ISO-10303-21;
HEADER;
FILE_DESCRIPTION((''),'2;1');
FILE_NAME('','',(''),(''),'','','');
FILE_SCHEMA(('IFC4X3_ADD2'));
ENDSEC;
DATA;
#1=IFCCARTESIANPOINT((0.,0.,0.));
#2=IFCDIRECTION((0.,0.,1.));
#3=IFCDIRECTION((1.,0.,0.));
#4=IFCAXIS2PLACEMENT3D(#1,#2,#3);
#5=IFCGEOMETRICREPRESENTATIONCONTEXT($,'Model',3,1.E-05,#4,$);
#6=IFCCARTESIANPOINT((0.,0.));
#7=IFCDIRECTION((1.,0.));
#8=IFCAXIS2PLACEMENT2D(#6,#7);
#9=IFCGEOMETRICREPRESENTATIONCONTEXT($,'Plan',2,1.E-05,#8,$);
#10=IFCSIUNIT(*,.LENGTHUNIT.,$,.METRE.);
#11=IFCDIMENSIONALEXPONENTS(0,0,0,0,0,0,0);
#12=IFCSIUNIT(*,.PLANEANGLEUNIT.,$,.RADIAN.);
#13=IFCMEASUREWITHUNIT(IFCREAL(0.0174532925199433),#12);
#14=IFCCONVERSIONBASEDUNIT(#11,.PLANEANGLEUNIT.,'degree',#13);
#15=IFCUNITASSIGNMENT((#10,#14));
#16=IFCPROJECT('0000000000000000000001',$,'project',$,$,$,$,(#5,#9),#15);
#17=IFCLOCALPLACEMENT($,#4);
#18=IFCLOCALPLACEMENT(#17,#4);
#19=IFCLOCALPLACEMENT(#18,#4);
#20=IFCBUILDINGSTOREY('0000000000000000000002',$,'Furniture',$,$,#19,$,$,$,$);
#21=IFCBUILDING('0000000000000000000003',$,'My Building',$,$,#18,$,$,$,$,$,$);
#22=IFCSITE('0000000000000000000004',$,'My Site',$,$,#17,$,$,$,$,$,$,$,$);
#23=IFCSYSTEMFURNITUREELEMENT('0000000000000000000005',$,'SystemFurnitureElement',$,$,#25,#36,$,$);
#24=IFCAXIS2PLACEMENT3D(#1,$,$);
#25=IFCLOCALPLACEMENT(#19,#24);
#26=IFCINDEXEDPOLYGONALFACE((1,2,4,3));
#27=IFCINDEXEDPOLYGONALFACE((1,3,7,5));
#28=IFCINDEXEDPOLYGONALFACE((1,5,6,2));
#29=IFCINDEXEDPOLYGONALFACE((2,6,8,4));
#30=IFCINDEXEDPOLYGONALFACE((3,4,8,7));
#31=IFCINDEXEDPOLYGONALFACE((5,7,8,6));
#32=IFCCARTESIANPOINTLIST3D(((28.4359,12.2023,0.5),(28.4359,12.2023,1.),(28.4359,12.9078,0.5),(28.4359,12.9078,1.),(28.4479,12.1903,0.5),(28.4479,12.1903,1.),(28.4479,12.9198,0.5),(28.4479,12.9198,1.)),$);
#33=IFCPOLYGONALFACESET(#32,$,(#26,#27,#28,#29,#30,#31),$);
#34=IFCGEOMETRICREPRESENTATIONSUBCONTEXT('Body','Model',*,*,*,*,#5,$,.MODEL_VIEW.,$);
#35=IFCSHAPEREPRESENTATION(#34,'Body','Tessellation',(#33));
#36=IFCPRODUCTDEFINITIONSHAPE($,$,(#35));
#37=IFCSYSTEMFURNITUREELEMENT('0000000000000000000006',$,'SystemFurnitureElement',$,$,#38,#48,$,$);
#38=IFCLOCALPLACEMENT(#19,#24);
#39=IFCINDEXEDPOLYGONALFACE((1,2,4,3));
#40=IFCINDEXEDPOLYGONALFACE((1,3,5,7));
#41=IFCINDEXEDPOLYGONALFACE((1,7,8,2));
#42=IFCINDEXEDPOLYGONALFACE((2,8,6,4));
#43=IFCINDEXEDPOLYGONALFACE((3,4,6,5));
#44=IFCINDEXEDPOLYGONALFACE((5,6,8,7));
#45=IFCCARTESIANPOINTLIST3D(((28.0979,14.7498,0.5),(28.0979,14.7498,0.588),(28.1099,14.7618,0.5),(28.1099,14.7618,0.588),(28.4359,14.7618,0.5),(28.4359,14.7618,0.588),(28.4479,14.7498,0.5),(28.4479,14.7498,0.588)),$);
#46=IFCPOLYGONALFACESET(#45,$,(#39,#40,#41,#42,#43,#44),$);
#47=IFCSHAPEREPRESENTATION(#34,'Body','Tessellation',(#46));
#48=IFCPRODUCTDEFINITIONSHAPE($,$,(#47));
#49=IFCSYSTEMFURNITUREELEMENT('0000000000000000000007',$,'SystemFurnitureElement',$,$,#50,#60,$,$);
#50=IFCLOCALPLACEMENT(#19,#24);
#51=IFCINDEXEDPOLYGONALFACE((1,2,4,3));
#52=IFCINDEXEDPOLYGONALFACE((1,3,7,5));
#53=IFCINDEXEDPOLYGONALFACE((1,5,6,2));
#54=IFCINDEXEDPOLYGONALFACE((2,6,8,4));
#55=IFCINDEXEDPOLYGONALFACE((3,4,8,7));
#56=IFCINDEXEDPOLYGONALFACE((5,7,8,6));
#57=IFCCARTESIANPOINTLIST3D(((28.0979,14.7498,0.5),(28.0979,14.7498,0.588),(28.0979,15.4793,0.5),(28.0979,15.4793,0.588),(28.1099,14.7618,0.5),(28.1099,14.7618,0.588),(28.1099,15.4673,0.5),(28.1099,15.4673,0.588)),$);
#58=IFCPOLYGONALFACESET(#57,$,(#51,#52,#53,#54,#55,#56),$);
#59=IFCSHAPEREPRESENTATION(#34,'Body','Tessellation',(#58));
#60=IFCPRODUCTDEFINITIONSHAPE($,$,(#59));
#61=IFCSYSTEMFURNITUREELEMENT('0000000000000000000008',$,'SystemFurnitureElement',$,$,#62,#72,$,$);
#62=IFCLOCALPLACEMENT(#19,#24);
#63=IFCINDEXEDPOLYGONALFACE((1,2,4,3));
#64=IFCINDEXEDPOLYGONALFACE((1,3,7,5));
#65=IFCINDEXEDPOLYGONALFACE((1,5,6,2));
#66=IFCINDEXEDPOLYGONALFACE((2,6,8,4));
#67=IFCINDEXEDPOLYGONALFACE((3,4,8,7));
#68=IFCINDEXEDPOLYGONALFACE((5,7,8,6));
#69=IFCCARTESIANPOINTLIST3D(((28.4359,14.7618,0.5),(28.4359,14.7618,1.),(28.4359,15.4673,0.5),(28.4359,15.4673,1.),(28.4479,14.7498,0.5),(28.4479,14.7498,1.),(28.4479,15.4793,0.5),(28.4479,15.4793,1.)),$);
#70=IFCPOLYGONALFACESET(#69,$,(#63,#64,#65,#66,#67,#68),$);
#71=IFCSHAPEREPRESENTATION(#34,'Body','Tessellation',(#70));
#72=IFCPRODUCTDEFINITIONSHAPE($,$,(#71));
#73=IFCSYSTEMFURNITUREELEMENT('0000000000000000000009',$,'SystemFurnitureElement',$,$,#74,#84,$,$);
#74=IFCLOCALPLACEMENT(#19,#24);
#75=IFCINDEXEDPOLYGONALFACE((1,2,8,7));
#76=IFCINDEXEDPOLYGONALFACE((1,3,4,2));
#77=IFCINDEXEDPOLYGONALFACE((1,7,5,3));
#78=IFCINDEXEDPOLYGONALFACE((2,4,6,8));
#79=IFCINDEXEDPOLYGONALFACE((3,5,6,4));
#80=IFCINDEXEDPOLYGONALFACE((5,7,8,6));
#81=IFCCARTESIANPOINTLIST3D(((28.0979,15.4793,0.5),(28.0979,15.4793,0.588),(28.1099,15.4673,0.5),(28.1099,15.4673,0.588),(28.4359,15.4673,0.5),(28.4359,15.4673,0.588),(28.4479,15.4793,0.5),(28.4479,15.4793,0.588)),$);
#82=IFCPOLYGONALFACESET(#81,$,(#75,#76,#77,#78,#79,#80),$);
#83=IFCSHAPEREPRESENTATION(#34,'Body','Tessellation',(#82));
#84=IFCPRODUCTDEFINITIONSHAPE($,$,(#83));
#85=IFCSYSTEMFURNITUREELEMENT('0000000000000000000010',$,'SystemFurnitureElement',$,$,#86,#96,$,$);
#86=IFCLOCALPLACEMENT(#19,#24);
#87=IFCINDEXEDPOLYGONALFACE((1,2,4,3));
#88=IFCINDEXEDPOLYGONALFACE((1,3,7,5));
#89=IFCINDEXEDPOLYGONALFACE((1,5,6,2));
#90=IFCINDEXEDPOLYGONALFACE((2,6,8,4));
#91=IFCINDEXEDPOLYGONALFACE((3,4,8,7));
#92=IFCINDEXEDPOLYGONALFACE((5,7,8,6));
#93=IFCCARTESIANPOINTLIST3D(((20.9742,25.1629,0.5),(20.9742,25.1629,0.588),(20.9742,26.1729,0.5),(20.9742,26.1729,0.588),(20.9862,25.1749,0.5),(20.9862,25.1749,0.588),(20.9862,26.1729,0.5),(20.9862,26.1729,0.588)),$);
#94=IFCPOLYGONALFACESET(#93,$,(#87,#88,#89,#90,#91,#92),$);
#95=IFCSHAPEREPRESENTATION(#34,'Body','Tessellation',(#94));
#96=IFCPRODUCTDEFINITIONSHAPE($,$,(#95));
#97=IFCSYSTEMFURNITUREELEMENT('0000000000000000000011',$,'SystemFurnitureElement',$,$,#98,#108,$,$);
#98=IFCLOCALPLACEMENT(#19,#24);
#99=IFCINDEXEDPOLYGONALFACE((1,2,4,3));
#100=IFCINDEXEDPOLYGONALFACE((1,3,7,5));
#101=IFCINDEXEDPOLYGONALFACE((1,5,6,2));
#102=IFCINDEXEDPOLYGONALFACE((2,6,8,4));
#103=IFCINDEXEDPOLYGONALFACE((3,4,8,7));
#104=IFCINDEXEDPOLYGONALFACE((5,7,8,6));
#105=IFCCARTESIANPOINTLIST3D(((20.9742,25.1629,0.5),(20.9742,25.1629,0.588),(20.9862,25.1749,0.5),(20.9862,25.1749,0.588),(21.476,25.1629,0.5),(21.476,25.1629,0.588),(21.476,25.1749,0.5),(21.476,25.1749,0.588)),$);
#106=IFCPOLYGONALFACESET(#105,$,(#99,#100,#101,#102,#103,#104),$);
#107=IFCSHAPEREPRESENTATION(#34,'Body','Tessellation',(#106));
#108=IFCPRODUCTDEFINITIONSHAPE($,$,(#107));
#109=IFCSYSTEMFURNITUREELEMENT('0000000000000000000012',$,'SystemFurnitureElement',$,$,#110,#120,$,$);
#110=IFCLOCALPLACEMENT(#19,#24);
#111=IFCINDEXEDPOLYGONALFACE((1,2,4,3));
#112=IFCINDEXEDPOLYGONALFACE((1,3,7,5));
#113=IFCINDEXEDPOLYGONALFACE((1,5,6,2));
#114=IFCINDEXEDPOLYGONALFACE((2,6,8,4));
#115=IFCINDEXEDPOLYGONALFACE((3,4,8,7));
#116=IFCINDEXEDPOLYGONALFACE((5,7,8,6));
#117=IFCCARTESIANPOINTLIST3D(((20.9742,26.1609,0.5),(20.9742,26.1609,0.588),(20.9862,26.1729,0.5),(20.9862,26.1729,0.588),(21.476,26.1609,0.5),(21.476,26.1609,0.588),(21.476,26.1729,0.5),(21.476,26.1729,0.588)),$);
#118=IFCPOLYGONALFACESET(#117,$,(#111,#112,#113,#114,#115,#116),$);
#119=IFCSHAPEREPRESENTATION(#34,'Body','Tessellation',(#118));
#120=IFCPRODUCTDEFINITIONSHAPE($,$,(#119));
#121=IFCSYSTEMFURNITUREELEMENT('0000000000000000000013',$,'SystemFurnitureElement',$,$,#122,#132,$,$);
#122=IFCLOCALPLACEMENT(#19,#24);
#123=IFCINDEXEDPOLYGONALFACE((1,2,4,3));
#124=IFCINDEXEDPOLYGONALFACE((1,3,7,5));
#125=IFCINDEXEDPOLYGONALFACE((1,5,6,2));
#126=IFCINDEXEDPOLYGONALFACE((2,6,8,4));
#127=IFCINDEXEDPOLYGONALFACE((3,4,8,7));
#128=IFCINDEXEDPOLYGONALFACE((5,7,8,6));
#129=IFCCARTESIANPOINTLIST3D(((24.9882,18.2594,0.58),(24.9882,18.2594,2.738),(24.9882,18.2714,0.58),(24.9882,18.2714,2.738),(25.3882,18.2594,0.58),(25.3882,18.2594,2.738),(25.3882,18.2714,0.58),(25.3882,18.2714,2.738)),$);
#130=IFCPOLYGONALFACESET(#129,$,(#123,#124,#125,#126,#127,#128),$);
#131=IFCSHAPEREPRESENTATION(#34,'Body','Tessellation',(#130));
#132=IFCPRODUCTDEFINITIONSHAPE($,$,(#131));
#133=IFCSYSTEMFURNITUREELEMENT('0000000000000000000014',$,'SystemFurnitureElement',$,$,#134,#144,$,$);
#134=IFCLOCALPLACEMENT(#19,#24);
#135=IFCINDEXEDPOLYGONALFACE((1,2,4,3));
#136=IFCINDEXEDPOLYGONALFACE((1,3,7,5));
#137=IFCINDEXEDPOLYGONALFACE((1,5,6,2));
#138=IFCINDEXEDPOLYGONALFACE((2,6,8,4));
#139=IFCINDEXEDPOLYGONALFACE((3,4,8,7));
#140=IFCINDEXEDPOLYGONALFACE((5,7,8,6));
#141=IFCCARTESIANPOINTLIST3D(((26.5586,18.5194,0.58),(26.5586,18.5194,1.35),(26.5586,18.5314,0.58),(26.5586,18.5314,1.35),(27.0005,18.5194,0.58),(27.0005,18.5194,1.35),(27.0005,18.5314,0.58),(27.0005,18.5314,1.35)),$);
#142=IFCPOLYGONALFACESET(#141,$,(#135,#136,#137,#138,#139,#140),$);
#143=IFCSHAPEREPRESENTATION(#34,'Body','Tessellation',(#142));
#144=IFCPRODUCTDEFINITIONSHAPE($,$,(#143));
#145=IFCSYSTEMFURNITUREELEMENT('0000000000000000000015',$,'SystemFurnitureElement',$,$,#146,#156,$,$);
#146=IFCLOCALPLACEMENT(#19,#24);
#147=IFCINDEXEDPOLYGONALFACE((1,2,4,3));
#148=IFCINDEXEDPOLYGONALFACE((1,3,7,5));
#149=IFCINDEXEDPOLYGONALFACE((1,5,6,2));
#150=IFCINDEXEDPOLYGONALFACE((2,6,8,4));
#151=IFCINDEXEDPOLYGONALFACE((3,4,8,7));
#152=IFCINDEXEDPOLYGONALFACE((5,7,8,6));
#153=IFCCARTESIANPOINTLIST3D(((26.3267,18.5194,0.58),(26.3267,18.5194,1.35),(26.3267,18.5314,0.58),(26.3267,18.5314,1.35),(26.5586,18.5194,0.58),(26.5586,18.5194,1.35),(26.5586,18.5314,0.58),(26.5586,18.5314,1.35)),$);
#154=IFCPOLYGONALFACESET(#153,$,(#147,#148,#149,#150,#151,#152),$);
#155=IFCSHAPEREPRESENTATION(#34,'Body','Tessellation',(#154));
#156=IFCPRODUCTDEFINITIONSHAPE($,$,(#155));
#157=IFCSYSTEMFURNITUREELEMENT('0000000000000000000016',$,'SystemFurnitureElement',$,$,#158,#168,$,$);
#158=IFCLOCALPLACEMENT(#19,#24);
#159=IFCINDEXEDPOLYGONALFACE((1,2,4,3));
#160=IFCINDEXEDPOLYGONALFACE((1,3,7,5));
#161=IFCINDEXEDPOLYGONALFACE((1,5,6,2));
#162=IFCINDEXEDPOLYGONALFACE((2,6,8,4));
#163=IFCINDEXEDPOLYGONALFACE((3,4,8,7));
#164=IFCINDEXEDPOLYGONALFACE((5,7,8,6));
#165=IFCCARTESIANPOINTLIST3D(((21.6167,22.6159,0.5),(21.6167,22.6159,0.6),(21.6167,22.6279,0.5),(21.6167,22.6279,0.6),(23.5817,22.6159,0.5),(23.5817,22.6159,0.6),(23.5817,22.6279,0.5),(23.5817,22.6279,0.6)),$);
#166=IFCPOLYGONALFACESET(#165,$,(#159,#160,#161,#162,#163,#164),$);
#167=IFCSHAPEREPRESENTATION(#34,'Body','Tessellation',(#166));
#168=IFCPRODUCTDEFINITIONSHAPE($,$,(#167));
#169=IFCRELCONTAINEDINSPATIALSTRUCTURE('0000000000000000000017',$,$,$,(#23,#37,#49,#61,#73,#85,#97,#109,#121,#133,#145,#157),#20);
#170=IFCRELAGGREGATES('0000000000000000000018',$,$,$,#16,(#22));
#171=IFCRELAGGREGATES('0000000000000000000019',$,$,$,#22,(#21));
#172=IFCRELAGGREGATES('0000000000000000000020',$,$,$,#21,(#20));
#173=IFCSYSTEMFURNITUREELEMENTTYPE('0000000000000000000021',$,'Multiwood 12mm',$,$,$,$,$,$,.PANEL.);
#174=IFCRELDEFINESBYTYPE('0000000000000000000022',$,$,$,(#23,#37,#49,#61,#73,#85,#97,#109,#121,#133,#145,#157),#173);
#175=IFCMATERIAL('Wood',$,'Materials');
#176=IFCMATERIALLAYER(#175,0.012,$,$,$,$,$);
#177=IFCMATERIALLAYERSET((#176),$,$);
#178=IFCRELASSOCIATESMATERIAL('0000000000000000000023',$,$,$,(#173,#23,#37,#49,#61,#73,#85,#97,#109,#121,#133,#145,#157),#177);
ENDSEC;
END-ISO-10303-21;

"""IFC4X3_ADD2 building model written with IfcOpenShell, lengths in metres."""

from ifc_helpers import new_model, entity, si_unit, converted_unit, frame, origin_with_axes, origin_2d_with_axis, place, context, subcontext, project, spatial, line, indexed_curve, outline, extrude, material, layer, layer_set, layer_usage, type_object, element, save


model = new_model("IFC4X3_ADD2")

# Units and contexts
model_context = context("Model", 3, precision=1e-05, world=origin_with_axes())
plan_context = context("Plan", 2, precision=1e-05, world=origin_2d_with_axis())
body_context = subcontext(model_context, "Body", "Model", "MODEL_VIEW")
ifc_project = project(units=[si_unit("LENGTHUNIT", "METRE"), converted_unit("PLANEANGLEUNIT", "degree", entity("IfcReal", 0.0174532925199433), si_unit("PLANEANGLEUNIT", "RADIAN"), dimensions=[0, 0, 0, 0, 0, 0, 0])], contexts=[model_context, plan_context])

# Site, building, storey
site_placement = place(None, origin_with_axes())
site = spatial("IfcSite", under=ifc_project, at=site_placement, Name="My Site")
building_placement = place(site_placement, origin_with_axes())
building = spatial("IfcBuilding", under=site, at=building_placement, Name="My Building")
storey_placement = place(building_placement, origin_with_axes())
storey = spatial("IfcBuildingStorey", under=building, at=storey_placement, Name="Furniture")

# System furniture elements
ifc_material = material(Name="Wood", Category="Materials")
ifc_layer_1 = layer(ifc_material, 0.012)
ifc_layer_set_1 = layer_set([ifc_layer_1])
system_furniture_element_type_1 = type_object("IfcSystemFurnitureElementType", Name="Multiwood 12mm", PredefinedType="PANEL", material=ifc_layer_set_1)
ifc_layer_usage_1 = layer_usage(ifc_layer_set_1, "AXIS2", "POSITIVE", 0.0)
system_furniture_element_1_placement = place(storey_placement, frame((28.4359, 12.9078, 0.5), z_axis=(0.0, 0.0, 1.0), x_axis=(0.0, -1.0, 0.0)))
element("IfcSystemFurnitureElement", 1, at=system_furniture_element_1_placement, inside=storey, type_object=system_furniture_element_type_1, material=ifc_layer_usage_1, Name="SystemFurnitureElement", context=body_context, shape_type="SweptSolid", body=[
    extrude(outline(indexed_curve([(0.0, 0.0), (-0.012, 0.012), (0.7175, 0.012), (0.7055, 0.0)], segments=[line(1, 2, 3, 4, 1)])), origin_with_axes(), (0.0, 0.0, 1.0), 0.5),
])
ifc_layer_usage_2 = layer_usage(ifc_layer_set_1, "AXIS2", "POSITIVE", 0.0)
system_furniture_element_2_placement = place(storey_placement, frame((28.0979, 14.7498, 0.5), z_axis=(0.0, 0.0, 1.0), x_axis=(1.0, 0.0, 0.0)))
element("IfcSystemFurnitureElement", 2, at=system_furniture_element_2_placement, inside=storey, type_object=system_furniture_element_type_1, material=ifc_layer_usage_2, Name="SystemFurnitureElement", context=body_context, shape_type="SweptSolid", body=[
    extrude(outline(indexed_curve([(0.0, 0.0), (0.012, 0.012), (0.338, 0.012), (0.35, 0.0)], segments=[line(1, 2, 3, 4, 1)])), origin_with_axes(), (0.0, 0.0, 1.0), 0.088),
])
ifc_layer_usage_3 = layer_usage(ifc_layer_set_1, "AXIS2", "POSITIVE", 0.0)
system_furniture_element_3_placement = place(storey_placement, frame((28.0979, 15.4673, 0.5), z_axis=(0.0, 0.0, 1.0), x_axis=(0.0, -1.0, 0.0)))
element("IfcSystemFurnitureElement", 3, at=system_furniture_element_3_placement, inside=storey, type_object=system_furniture_element_type_1, material=ifc_layer_usage_3, Name="SystemFurnitureElement", context=body_context, shape_type="SweptSolid", body=[
    extrude(outline(indexed_curve([(-0.012, 0.0), (0.0, 0.012), (0.7055, 0.012), (0.7175, 0.0)], segments=[line(1, 2, 3, 4, 1)])), origin_with_axes(), (0.0, 0.0, 1.0), 0.088),
])
ifc_layer_usage_4 = layer_usage(ifc_layer_set_1, "AXIS2", "POSITIVE", 0.0)
system_furniture_element_4_placement = place(storey_placement, frame((28.4359, 15.4673, 0.5), z_axis=(0.0, 0.0, 1.0), x_axis=(0.0, -1.0, 0.0)))
element("IfcSystemFurnitureElement", 4, at=system_furniture_element_4_placement, inside=storey, type_object=system_furniture_element_type_1, material=ifc_layer_usage_4, Name="SystemFurnitureElement", context=body_context, shape_type="SweptSolid", body=[
    extrude(outline(indexed_curve([(0.0, 0.0), (-0.012, 0.012), (0.7175, 0.012), (0.7055, 0.0)], segments=[line(1, 2, 3, 4, 1)])), origin_with_axes(), (0.0, 0.0, 1.0), 0.5),
])
ifc_layer_usage_5 = layer_usage(ifc_layer_set_1, "AXIS2", "POSITIVE", 0.0)
system_furniture_element_5_placement = place(storey_placement, frame((28.0979, 15.4673, 0.5), z_axis=(0.0, 0.0, 1.0), x_axis=(1.0, 0.0, 0.0)))
element("IfcSystemFurnitureElement", 5, at=system_furniture_element_5_placement, inside=storey, type_object=system_furniture_element_type_1, material=ifc_layer_usage_5, Name="SystemFurnitureElement", context=body_context, shape_type="SweptSolid", body=[
    extrude(outline(indexed_curve([(0.012, 0.0), (0.0, 0.012), (0.35, 0.012), (0.338, 0.0)], segments=[line(1, 2, 3, 4, 1)])), origin_with_axes(), (0.0, 0.0, 1.0), 0.088),
])
ifc_layer_usage_6 = layer_usage(ifc_layer_set_1, "AXIS2", "POSITIVE", 0.0)
system_furniture_element_6_placement = place(storey_placement, frame((20.9742, 26.1729, 0.5), z_axis=(0.0, 0.0, 1.0), x_axis=(-0.000001, -1.0, 0.0)))
element("IfcSystemFurnitureElement", 6, at=system_furniture_element_6_placement, inside=storey, type_object=system_furniture_element_type_1, material=ifc_layer_usage_6, Name="SystemFurnitureElement", context=body_context, shape_type="SweptSolid", body=[
    extrude(outline(indexed_curve([(0.0, 0.0), (0.0, 0.012), (0.998, 0.012), (1.01, 0.0)], segments=[line(1, 2, 3, 4, 1)])), origin_with_axes(), (0.0, 0.0, 1.0), 0.088),
])
ifc_layer_usage_7 = layer_usage(ifc_layer_set_1, "AXIS2", "POSITIVE", 0.0)
system_furniture_element_7_placement = place(storey_placement, frame((20.9742, 25.1629, 0.5), z_axis=(0.0, 0.0, 1.0), x_axis=(1.0, -0.000001, 0.0)))
element("IfcSystemFurnitureElement", 7, at=system_furniture_element_7_placement, inside=storey, type_object=system_furniture_element_type_1, material=ifc_layer_usage_7, Name="SystemFurnitureElement", context=body_context, shape_type="SweptSolid", body=[
    extrude(outline(indexed_curve([(0.0, 0.0), (0.012, 0.012), (0.5019, 0.012), (0.5019, 0.0)], segments=[line(1, 2, 3, 4, 1)])), origin_with_axes(), (0.0, 0.0, 1.0), 0.088),
])
ifc_layer_usage_8 = layer_usage(ifc_layer_set_1, "AXIS2", "POSITIVE", 0.0)
system_furniture_element_8_placement = place(storey_placement, frame((20.9742, 26.1609, 0.5), z_axis=(0.0, 0.0, 1.0), x_axis=(1.0, -0.000001, 0.0)))
element("IfcSystemFurnitureElement", 8, at=system_furniture_element_8_placement, inside=storey, type_object=system_furniture_element_type_1, material=ifc_layer_usage_8, Name="SystemFurnitureElement", context=body_context, shape_type="SweptSolid", body=[
    extrude(outline(indexed_curve([(0.0, 0.0), (0.012, 0.012), (0.5019, 0.012), (0.5019, 0.0)], segments=[line(1, 2, 3, 4, 1)])), origin_with_axes(), (0.0, 0.0, 1.0), 0.088),
])
ifc_layer_usage_9 = layer_usage(ifc_layer_set_1, "AXIS2", "POSITIVE", 0.0)
system_furniture_element_9_placement = place(storey_placement, frame((25.3882, 18.2714, 0.58), z_axis=(0.0, 0.0, 1.0), x_axis=(-1.0, 0.0, 0.0)))
element("IfcSystemFurnitureElement", 9, at=system_furniture_element_9_placement, inside=storey, type_object=system_furniture_element_type_1, material=ifc_layer_usage_9, Name="SystemFurnitureElement", context=body_context, shape_type="SweptSolid", body=[
    extrude(outline(indexed_curve([(0.0, 0.0), (0.0, 0.012), (0.4, 0.012), (0.4, 0.0)], segments=[line(1, 2, 3, 4, 1)])), origin_with_axes(), (0.0, 0.0, 1.0), 2.158),
])
ifc_layer_usage_10 = layer_usage(ifc_layer_set_1, "AXIS2", "POSITIVE", 0.0)
system_furniture_element_10_placement = place(storey_placement, frame((27.0005, 18.5314, 0.58), z_axis=(0.0, 0.0, 1.0), x_axis=(-1.0, 0.0, 0.0)))
element("IfcSystemFurnitureElement", 10, at=system_furniture_element_10_placement, inside=storey, type_object=system_furniture_element_type_1, material=ifc_layer_usage_10, Name="SystemFurnitureElement", context=body_context, shape_type="SweptSolid", body=[
    extrude(outline(indexed_curve([(0.0, 0.0), (0.0, 0.012), (0.4419, 0.012), (0.4419, 0.0)], segments=[line(1, 2, 3, 4, 1)])), origin_with_axes(), (0.0, 0.0, 1.0), 0.77),
])
ifc_layer_usage_11 = layer_usage(ifc_layer_set_1, "AXIS2", "POSITIVE", 0.0)
system_furniture_element_11_placement = place(storey_placement, frame((26.5586, 18.5314, 0.58), z_axis=(0.0, 0.0, 1.0), x_axis=(-1.0, 0.0, 0.0)))
element("IfcSystemFurnitureElement", 11, at=system_furniture_element_11_placement, inside=storey, type_object=system_furniture_element_type_1, material=ifc_layer_usage_11, Name="SystemFurnitureElement", context=body_context, shape_type="SweptSolid", body=[
    extrude(outline(indexed_curve([(0.0, 0.0), (0.0, 0.012), (0.2319, 0.012), (0.2319, 0.0)], segments=[line(1, 2, 3, 4, 1)])), origin_with_axes(), (0.0, 0.0, 1.0), 0.77),
])
ifc_layer_usage_12 = layer_usage(ifc_layer_set_1, "AXIS2", "POSITIVE", 0.0)
system_furniture_element_12_placement = place(storey_placement, frame((23.5817, 22.6279, 0.5), z_axis=(0.0, 0.0, 1.0), x_axis=(-1.0, 0.000002, 0.0)))
element("IfcSystemFurnitureElement", 12, at=system_furniture_element_12_placement, inside=storey, type_object=system_furniture_element_type_1, material=ifc_layer_usage_12, Name="SystemFurnitureElement", context=body_context, shape_type="SweptSolid", body=[
    extrude(outline(indexed_curve([(0.0, 0.0), (0.0, 0.012), (1.965, 0.012), (1.965, 0.0)], segments=[line(1, 2, 3, 4, 1)])), origin_with_axes(), (0.0, 0.0, 1.0), 0.1),
])

save(model, "model.ifc")
